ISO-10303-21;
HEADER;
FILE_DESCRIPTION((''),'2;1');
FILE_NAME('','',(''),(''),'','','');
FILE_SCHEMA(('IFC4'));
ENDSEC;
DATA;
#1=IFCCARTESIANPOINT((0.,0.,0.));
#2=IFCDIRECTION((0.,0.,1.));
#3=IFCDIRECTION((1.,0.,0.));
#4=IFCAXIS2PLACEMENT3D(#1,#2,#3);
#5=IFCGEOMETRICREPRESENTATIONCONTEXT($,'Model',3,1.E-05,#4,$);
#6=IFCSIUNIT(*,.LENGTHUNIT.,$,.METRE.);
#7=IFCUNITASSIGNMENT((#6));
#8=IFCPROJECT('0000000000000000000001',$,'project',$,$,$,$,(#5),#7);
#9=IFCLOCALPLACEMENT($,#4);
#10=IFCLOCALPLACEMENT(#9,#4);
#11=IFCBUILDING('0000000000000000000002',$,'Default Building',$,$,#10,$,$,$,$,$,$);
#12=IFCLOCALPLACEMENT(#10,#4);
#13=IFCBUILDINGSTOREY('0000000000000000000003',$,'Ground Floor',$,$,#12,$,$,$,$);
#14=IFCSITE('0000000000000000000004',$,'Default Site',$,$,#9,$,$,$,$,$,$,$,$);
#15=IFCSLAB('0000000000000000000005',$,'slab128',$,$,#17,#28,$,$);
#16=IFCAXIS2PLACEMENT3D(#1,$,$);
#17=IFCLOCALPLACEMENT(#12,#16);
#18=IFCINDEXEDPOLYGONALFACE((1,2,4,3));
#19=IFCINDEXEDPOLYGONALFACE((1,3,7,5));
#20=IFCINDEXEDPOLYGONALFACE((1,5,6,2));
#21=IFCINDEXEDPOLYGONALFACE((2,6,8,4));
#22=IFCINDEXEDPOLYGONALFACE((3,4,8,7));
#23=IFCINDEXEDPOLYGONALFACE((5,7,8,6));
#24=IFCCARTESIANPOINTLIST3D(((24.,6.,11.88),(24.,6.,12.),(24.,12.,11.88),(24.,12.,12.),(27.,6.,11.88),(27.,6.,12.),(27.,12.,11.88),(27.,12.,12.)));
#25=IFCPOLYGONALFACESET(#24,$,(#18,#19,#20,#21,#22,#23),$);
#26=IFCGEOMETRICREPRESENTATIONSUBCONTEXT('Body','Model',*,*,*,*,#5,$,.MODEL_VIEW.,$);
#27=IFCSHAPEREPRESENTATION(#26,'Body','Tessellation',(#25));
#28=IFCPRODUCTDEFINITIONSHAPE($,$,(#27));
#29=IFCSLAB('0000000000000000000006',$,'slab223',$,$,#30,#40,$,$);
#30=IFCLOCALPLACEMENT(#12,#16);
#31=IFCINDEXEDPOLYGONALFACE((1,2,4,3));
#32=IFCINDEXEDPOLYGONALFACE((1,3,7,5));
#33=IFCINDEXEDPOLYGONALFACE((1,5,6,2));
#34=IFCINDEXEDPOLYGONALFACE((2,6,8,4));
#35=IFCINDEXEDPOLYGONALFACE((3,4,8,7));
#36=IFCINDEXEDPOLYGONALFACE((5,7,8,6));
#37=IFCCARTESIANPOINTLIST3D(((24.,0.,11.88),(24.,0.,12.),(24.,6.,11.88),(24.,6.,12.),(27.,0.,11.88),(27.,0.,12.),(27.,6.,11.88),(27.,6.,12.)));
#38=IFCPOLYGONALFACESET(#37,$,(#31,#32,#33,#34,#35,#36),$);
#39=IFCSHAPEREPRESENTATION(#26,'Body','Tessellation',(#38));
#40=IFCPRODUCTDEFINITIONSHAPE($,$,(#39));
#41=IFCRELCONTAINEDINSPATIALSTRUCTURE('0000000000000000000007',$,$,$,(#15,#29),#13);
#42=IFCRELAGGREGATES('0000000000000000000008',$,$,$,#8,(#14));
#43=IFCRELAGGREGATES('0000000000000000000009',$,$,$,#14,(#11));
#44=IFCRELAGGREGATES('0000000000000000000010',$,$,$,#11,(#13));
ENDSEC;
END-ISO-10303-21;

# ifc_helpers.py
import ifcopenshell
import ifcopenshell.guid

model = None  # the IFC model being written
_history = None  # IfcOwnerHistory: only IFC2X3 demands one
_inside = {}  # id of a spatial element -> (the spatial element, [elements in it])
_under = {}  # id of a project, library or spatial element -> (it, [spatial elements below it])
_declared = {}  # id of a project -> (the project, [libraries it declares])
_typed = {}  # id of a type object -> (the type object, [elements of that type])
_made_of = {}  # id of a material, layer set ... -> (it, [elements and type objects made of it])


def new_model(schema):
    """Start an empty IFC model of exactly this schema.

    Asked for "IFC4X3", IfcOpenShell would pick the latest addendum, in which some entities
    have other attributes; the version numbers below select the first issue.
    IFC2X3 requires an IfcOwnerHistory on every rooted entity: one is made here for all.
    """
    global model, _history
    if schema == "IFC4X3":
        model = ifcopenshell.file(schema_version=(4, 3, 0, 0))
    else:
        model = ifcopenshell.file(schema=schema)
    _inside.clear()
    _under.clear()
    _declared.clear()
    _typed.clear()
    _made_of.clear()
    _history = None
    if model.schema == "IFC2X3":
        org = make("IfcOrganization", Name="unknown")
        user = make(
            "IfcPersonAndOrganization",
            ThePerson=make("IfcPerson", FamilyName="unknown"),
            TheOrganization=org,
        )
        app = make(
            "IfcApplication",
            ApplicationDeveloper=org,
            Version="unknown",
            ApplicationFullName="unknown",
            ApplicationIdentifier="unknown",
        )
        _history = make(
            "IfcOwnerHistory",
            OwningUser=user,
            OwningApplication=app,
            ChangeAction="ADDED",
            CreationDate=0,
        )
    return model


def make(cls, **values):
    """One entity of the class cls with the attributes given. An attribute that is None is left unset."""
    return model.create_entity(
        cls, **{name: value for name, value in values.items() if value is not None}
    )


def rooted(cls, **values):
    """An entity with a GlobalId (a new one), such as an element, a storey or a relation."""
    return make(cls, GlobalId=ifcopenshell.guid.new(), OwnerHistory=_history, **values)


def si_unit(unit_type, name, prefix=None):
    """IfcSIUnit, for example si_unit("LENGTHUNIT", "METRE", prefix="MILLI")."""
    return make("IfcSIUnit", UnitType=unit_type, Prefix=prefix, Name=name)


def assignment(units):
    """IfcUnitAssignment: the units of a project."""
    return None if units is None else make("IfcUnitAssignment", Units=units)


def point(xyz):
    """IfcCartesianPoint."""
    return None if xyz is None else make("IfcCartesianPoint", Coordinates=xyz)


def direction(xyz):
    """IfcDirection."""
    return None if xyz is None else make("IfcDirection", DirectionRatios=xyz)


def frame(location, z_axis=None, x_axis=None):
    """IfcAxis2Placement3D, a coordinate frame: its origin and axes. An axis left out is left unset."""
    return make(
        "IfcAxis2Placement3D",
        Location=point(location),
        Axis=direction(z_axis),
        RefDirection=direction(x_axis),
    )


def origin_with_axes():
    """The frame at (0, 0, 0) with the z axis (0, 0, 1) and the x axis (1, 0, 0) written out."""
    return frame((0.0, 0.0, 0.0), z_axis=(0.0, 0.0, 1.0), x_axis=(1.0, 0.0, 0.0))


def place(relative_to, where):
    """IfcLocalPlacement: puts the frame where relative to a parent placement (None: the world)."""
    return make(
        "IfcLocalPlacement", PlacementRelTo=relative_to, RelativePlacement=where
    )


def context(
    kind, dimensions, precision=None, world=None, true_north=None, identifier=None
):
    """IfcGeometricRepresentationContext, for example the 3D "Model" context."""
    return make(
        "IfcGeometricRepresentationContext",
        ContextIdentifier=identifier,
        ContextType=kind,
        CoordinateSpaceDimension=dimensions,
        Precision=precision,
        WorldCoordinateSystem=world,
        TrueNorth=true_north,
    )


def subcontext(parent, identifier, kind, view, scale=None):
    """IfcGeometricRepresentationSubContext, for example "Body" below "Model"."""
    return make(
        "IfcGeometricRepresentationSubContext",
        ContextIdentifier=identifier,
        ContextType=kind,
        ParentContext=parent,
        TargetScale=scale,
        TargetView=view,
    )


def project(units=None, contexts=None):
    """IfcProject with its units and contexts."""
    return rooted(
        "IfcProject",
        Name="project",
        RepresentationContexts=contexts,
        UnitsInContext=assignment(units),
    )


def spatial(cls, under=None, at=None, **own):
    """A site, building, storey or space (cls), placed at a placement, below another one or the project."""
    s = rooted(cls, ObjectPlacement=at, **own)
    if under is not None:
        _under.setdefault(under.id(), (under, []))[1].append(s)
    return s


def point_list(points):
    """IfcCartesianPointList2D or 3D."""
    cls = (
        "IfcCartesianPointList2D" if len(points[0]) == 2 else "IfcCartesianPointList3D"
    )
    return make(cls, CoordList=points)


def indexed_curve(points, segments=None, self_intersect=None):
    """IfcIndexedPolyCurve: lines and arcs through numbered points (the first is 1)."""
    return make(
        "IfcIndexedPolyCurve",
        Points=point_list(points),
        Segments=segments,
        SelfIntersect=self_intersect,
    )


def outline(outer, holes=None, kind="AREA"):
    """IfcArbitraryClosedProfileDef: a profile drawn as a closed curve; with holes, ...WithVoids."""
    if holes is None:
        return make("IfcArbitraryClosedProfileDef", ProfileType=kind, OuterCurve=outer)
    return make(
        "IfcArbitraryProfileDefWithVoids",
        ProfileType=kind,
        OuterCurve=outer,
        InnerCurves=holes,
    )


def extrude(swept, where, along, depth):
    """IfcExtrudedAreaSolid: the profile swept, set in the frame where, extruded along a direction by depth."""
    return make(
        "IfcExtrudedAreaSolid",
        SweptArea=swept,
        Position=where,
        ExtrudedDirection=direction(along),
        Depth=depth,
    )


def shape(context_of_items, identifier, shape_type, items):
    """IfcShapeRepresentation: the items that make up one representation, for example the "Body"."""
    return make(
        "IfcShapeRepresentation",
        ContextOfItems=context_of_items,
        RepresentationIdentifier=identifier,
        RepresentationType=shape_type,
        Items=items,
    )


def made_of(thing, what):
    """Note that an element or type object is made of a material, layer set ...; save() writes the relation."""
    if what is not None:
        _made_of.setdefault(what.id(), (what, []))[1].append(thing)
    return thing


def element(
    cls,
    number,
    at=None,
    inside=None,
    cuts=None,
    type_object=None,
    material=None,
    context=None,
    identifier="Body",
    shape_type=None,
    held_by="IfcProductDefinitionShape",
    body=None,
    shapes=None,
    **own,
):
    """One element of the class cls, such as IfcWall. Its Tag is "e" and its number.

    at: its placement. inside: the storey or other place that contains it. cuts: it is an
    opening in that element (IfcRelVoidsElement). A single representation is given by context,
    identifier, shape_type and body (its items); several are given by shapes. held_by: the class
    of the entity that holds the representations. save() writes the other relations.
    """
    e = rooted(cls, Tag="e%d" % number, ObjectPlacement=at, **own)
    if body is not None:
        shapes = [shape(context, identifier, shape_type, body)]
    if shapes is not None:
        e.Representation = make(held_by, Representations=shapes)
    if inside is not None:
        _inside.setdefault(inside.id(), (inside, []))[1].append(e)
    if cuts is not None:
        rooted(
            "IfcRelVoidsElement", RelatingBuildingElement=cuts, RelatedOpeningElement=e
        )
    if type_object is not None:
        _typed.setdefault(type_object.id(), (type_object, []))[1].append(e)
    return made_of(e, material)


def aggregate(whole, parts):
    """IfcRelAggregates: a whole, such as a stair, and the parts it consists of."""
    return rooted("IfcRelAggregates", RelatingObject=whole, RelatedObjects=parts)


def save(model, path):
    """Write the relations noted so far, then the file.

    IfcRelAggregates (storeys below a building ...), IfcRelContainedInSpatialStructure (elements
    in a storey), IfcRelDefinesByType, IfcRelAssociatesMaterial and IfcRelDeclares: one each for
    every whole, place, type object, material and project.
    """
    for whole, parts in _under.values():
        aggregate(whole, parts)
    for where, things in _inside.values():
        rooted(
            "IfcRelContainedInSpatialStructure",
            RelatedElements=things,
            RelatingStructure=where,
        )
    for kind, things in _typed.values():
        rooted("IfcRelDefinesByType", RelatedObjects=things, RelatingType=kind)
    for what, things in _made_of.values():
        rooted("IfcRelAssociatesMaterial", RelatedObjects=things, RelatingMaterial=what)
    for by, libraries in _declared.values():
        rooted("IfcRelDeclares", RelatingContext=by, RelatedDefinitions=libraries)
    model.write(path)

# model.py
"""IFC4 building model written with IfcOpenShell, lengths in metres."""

from ifc_helpers import new_model, si_unit, frame, origin_with_axes, place, context, subcontext, project, spatial, indexed_curve, outline, extrude, element, save


model = new_model("IFC4")

# Units and contexts
model_context = context("Model", 3, precision=1e-05, world=origin_with_axes())
body_context = subcontext(model_context, "Body", "Model", "MODEL_VIEW")
ifc_project = project(units=[si_unit("LENGTHUNIT", "METRE")], contexts=[model_context])

# Site, building, storey
site_placement = place(None, origin_with_axes())
site = spatial("IfcSite", under=ifc_project, at=site_placement, Name="Default Site")
building_placement = place(site_placement, origin_with_axes())
building = spatial("IfcBuilding", under=site, at=building_placement, Name="Default Building")
storey_placement = place(building_placement, origin_with_axes())
storey = spatial("IfcBuildingStorey", under=building, at=storey_placement, Name="Ground Floor")

# Slabs
for number, where, z_axis, x_axis, name in (
    (1, (24.0, 6.0, 11.88), (0.0, 0.0, 1.0), (1.0, 0.0, 0.0), "slab128"),
    (2, (24.0, 0.0, 11.88), (0.0, 0.0, 1.0), (1.0, 0.0, 0.0), "slab223"),
):
    element("IfcSlab", number, at=place(storey_placement, frame(where, z_axis=z_axis, x_axis=x_axis)), inside=storey, Name=name, context=body_context, shape_type="SweptSolid", body=[
        extrude(outline(indexed_curve([(0.0, 0.0), (0.0, 6.0), (3.0, 6.0), (3.0, 0.0), (0.0, 0.0)], self_intersect=False)), origin_with_axes(), (0.0, 0.0, 1.0), 0.12),
    ])

save(model, "model.ifc")
